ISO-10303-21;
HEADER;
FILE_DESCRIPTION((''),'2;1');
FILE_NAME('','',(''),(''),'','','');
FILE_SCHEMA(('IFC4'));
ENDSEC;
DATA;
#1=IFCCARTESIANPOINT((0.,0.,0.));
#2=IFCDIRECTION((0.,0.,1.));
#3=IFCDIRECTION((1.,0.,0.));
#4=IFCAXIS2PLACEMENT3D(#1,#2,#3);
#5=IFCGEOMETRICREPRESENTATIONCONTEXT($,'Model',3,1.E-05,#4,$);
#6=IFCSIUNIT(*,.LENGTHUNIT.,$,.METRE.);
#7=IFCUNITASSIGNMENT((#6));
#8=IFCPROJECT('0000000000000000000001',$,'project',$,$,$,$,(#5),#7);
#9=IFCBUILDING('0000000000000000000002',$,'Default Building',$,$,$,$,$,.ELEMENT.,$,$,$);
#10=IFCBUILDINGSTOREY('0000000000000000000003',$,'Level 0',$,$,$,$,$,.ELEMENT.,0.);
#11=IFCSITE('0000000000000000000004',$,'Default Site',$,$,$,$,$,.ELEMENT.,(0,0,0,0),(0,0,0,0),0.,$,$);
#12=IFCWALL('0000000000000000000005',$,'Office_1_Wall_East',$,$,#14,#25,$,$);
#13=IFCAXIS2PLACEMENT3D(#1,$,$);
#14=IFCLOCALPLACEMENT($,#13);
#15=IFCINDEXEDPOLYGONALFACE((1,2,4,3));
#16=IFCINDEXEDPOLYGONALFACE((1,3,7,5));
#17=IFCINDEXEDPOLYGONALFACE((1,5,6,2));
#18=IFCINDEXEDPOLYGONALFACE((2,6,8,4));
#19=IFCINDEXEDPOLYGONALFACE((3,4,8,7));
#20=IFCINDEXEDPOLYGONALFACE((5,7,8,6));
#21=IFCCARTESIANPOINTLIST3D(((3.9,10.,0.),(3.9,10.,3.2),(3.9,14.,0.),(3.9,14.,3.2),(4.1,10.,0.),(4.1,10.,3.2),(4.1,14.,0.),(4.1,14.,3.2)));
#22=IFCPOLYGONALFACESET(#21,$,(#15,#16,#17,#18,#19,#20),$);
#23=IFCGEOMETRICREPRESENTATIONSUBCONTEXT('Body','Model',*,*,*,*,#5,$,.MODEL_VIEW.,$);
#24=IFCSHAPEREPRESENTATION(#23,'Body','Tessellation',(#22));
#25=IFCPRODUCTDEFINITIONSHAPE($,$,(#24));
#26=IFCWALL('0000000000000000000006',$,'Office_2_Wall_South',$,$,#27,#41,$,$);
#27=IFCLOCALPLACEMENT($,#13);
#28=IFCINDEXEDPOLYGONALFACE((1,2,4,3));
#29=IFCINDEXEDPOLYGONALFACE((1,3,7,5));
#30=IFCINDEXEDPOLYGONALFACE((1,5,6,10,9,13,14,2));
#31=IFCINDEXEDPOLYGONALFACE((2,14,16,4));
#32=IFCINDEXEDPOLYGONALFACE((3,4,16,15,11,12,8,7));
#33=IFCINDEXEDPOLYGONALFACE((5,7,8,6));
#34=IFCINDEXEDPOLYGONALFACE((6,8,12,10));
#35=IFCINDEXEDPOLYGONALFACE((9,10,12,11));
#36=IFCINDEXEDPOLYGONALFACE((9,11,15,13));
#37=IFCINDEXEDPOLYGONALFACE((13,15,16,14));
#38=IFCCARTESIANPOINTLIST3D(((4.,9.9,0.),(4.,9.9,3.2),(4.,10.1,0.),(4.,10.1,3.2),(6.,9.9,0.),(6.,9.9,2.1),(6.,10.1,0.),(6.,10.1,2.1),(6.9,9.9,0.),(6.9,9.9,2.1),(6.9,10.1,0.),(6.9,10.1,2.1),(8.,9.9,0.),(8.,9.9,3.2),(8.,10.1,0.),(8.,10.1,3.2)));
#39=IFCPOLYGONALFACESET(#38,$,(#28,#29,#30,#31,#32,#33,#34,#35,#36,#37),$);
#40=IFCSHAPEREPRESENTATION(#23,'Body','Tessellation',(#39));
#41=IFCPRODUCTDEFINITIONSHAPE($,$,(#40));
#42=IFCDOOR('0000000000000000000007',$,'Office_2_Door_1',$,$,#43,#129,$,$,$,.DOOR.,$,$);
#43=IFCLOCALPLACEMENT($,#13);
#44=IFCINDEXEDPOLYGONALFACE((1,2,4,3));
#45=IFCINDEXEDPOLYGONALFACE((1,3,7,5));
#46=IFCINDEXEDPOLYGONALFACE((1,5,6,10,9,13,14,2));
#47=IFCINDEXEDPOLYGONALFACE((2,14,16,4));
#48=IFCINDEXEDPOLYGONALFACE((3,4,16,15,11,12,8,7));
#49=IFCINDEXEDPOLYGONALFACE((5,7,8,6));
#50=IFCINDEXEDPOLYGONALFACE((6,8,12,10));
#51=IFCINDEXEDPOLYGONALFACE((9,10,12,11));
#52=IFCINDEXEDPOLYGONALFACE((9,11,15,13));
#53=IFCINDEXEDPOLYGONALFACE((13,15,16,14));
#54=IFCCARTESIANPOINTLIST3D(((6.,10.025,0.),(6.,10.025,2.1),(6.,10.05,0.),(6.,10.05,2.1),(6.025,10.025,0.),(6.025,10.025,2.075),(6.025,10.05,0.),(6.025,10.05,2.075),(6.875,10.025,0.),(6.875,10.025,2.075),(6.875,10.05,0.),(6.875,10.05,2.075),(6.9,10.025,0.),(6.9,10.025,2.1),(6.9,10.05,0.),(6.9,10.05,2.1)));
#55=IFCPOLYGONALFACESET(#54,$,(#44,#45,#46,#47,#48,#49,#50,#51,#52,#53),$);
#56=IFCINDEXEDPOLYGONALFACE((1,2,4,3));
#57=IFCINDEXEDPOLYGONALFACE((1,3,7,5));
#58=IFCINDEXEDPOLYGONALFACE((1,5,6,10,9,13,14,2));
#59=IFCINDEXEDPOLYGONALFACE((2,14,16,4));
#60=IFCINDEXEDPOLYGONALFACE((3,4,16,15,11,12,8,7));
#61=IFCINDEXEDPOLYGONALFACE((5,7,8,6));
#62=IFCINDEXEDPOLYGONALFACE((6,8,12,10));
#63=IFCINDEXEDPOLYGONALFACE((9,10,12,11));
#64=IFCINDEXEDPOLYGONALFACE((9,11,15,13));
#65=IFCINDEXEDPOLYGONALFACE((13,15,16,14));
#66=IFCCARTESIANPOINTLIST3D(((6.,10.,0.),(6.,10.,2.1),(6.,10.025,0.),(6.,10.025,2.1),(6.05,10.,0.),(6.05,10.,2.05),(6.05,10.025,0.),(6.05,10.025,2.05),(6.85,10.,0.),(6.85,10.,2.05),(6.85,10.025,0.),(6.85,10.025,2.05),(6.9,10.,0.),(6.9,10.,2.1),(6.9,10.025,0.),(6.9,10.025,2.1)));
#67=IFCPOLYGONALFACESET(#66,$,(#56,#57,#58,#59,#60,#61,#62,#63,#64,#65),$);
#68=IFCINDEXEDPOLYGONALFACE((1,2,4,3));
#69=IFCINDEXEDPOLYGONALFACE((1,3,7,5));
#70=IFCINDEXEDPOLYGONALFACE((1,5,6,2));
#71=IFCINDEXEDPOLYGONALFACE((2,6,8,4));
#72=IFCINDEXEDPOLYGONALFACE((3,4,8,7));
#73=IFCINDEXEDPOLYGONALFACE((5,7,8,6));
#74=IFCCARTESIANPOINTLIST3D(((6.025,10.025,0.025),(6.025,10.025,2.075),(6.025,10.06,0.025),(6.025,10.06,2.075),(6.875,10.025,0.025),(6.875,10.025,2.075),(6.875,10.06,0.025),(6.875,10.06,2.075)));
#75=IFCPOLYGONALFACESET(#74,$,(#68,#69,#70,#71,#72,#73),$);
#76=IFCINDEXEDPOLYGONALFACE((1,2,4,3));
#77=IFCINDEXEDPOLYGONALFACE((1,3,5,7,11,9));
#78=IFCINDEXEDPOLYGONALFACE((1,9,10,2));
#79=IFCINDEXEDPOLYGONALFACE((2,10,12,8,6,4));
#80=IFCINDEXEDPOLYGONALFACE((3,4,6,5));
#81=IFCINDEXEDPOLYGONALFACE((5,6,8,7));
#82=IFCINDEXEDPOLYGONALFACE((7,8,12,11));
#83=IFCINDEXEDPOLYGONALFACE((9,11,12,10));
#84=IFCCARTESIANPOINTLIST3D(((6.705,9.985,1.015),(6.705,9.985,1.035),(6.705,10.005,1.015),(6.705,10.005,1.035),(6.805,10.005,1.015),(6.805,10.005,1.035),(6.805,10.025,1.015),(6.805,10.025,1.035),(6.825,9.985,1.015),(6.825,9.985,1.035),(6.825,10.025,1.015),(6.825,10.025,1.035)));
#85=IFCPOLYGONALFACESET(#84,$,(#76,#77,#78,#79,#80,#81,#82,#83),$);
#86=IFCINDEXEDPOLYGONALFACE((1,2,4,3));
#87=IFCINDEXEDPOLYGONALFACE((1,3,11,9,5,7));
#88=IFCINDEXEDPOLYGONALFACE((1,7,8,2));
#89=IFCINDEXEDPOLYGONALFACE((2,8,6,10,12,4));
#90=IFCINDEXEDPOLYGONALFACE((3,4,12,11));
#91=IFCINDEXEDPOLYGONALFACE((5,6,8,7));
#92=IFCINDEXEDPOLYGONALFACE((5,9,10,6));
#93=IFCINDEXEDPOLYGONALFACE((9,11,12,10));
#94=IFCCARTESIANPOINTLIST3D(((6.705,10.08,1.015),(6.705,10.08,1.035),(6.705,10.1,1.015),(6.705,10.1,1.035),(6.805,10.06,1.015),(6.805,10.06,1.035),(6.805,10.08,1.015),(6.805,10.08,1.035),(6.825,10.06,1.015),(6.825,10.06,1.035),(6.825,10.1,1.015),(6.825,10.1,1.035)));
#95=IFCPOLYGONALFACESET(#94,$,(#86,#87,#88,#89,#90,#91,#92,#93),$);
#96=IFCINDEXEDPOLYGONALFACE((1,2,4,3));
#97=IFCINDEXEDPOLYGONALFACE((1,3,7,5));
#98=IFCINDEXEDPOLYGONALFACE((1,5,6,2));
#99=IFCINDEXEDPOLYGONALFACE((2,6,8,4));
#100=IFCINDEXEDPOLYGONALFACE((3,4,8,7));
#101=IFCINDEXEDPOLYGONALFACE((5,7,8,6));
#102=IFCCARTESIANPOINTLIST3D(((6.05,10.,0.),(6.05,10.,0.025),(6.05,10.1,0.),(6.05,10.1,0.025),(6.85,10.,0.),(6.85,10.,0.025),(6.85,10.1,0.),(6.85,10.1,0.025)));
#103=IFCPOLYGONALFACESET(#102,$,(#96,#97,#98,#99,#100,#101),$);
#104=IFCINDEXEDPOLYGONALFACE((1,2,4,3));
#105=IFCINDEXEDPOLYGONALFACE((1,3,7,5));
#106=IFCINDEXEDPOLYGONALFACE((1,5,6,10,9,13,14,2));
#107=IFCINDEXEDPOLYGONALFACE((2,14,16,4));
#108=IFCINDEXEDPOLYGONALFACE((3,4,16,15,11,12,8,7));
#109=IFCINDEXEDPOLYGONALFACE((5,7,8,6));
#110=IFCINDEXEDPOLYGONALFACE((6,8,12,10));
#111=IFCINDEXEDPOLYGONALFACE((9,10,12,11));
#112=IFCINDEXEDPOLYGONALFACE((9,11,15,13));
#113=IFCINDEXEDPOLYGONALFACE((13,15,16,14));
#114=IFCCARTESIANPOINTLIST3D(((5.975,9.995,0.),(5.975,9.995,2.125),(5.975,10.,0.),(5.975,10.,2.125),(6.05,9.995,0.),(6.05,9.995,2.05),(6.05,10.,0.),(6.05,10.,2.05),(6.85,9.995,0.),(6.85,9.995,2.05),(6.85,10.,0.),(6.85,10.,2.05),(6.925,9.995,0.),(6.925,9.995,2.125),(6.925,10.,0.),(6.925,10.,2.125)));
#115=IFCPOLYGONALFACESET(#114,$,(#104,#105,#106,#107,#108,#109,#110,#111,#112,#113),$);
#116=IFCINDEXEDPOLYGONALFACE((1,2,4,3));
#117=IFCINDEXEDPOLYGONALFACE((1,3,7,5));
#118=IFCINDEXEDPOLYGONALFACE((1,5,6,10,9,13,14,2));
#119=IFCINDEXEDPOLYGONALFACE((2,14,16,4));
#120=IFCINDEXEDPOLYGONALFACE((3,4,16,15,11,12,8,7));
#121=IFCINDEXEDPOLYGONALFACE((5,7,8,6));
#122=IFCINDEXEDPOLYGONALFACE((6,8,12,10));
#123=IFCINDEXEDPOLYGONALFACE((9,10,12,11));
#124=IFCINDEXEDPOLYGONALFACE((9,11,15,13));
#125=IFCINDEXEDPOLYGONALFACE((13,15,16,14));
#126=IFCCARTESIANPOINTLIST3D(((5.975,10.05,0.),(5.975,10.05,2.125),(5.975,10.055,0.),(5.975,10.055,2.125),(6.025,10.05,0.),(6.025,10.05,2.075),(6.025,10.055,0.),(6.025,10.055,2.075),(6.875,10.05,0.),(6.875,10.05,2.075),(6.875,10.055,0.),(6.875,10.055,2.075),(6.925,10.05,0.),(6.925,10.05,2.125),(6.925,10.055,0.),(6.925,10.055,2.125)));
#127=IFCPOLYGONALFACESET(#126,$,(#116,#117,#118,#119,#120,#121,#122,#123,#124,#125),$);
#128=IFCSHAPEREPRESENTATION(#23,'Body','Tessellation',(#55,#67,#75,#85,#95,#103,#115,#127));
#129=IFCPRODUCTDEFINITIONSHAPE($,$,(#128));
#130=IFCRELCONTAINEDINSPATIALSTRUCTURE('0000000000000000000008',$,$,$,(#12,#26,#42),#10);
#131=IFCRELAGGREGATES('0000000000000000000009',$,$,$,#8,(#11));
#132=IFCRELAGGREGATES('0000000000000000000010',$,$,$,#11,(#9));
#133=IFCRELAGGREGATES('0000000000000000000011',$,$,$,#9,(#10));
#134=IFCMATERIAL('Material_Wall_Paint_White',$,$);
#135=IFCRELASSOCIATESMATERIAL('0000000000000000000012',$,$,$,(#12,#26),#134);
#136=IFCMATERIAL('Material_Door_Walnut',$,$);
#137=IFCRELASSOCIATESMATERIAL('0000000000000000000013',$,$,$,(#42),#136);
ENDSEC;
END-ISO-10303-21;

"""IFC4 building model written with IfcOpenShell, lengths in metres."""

from ifc_helpers import new_model, si_unit, frame, origin_with_axes, place, context, subcontext, project, spatial, line, indexed_curve, outline, extrude, material, element, fill, save


model = new_model("IFC4")

# Units and contexts
model_context = context("Model", 3, precision=1e-05, world=origin_with_axes())
body_context = subcontext(model_context, "Body", "Model", "MODEL_VIEW")
ifc_project = project(units=[si_unit("LENGTHUNIT", "METRE")], contexts=[model_context])

# Site, building, storey
site = spatial("IfcSite", under=ifc_project, Name="Default Site", CompositionType="ELEMENT", RefLatitude=(0, 0, 0, 0), RefLongitude=(0, 0, 0, 0), RefElevation=0.0)
building = spatial("IfcBuilding", under=site, Name="Default Building", CompositionType="ELEMENT")
storey = spatial("IfcBuildingStorey", under=building, Name="Level 0", CompositionType="ELEMENT", Elevation=0.0)

# Shared definitions
ifc_material_1 = material(Name="Material_Wall_Paint_White")
ifc_material_2 = material(Name="Material_Door_Walnut")

# Wall
wall_1_placement = place(None, frame((4.0, 10.0, 0.0), z_axis=(0.0, 0.0, 1.0), x_axis=(0.0, 1.0, 0.0)))
element("IfcWall", 1, at=wall_1_placement, inside=storey, material=ifc_material_1, Name="Office_1_Wall_East", context=body_context, shape_type="SweptSolid", body=[
    extrude(outline(indexed_curve([(0.0, 0.0), (0.0, 0.2), (4.0, 0.2), (4.0, 0.0), (0.0, 0.0)], self_intersect=False)), frame((0.0, -0.1, 0.0), z_axis=(0.0, 0.0, 1.0), x_axis=(1.0, 0.0, 0.0)), (0.0, 0.0, 1.0), 3.2),
])

# Wall, opening, door
wall_2_placement = place(None, frame((4.0, 10.0, 0.0), z_axis=(0.0, 0.0, 1.0), x_axis=(1.0, 0.0, 0.0)))
wall_2 = element("IfcWall", 2, at=wall_2_placement, inside=storey, material=ifc_material_1, Name="Office_2_Wall_South", context=body_context, shape_type="SweptSolid", body=[
    extrude(outline(indexed_curve([(0.0, 0.0), (0.0, 0.2), (4.0, 0.2), (4.0, 0.0), (0.0, 0.0)], self_intersect=False)), frame((0.0, -0.1, 0.0), z_axis=(0.0, 0.0, 1.0), x_axis=(1.0, 0.0, 0.0)), (0.0, 0.0, 1.0), 3.2),
])
opening_1_placement = place(wall_2_placement, frame((2.0, -0.5, 0.0), z_axis=(0.0, 0.0, 1.0), x_axis=(1.0, 0.0, 0.0)))
opening_1 = element("IfcOpeningElement", 3, at=opening_1_placement, inside=storey, cuts=wall_2, PredefinedType="OPENING", context=body_context, shape_type="SweptSolid", body=[
    extrude(outline(indexed_curve([(0.0, 0.0), (0.0, 1.0), (0.9, 1.0), (0.9, 0.0), (0.0, 0.0)], self_intersect=False)), origin_with_axes(), (0.0, 0.0, 1.0), 2.1),
])
door_1_placement = place(None, frame((6.0, 10.0, 0.0), z_axis=(0.0, 0.0, 1.0), x_axis=(1.0, 0.0, 0.0)))
door_1 = element("IfcDoor", 4, at=door_1_placement, inside=storey, material=ifc_material_2, Name="Office_2_Door_1", PredefinedType="DOOR", context=body_context, shape_type="SweptSolid", body=[
    extrude(outline(indexed_curve([(0.0, 0.0), (0.0, 2.1), (0.9, 2.1), (0.9, 0.0), (0.875, 0.0), (0.875, 2.075), (0.025, 2.075), (0.025, 0.0)], segments=[line(1, 2, 3, 4, 5, 6, 7, 8, 1)])), frame((0.0, 0.025, 0.0), z_axis=(0.0, -1.0, 0.0), x_axis=(1.0, 0.0, 0.0)), (0.0, 0.0, -1.0), 0.025),
    extrude(outline(indexed_curve([(0.0, 0.0), (0.0, 2.1), (0.9, 2.1), (0.9, 0.0), (0.85, 0.0), (0.85, 2.05), (0.05, 2.05), (0.05, 0.0)], segments=[line(1, 2, 3, 4, 5, 6, 7, 8, 1)])), frame((0.0, 0.0, 0.0), z_axis=(0.0, -1.0, 0.0), x_axis=(1.0, 0.0, 0.0)), (0.0, 0.0, -1.0), 0.025),
    extrude(outline(indexed_curve([(0.0, 0.0), (0.85, 0.0), (0.85, 0.035), (0.0, 0.035)], segments=[line(1, 2, 3, 4, 1)])), frame((0.025, 0.025, 0.025), z_axis=(0.0, 0.0, 1.0), x_axis=(1.0, 0.0, 0.0)), (0.0, 0.0, 1.0), 2.05),
    extrude(outline(indexed_curve([(0.0, 0.0), (0.0, -0.04), (-0.12, -0.04), (-0.12, -0.02), (-0.02, -0.02), (-0.02, 0.0)], segments=[line(1, 2, 3, 4, 5, 6, 1)])), frame((0.825, 0.025, 1.015), z_axis=(0.0, 0.0, 1.0), x_axis=(1.0, 0.0, 0.0)), (0.0, 0.0, 1.0), 0.02),
    extrude(outline(indexed_curve([(0.0, 0.0), (0.0, 0.04), (-0.12, 0.04), (-0.12, 0.02), (-0.02, 0.02), (-0.02, 0.0)], segments=[line(1, 2, 3, 4, 5, 6, 1)])), frame((0.825, 0.06, 1.015), z_axis=(0.0, 0.0, 1.0), x_axis=(1.0, 0.0, 0.0)), (0.0, 0.0, 1.0), 0.02),
    extrude(outline(indexed_curve([(0.0, 0.0), (0.8, 0.0), (0.8, 0.1), (0.0, 0.1)], segments=[line(1, 2, 3, 4, 1)])), frame((0.05, 0.0, 0.0), z_axis=(0.0, 0.0, 1.0), x_axis=(1.0, 0.0, 0.0)), (0.0, 0.0, 1.0), 0.025),
    extrude(outline(indexed_curve([(0.0, 0.0), (0.0, 2.125), (0.95, 2.125), (0.95, 0.0), (0.875, 0.0), (0.875, 2.05), (0.075, 2.05), (0.075, 0.0)], segments=[line(1, 2, 3, 4, 5, 6, 7, 8, 1)])), frame((-0.025, -0.005, 0.0), z_axis=(0.0, -1.0, 0.0), x_axis=(1.0, 0.0, 0.0)), (0.0, 0.0, -1.0), 0.005),
    extrude(outline(indexed_curve([(0.0, 0.0), (0.0, 2.125), (0.95, 2.125), (0.95, 0.0), (0.9, 0.0), (0.9, 2.075), (0.05, 2.075), (0.05, 0.0)], segments=[line(1, 2, 3, 4, 5, 6, 7, 8, 1)])), frame((-0.025, 0.05, 0.0), z_axis=(0.0, -1.0, 0.0), x_axis=(1.0, 0.0, 0.0)), (0.0, 0.0, -1.0), 0.005),
])
fill(opening_1, door_1)

save(model, "model.ifc")
